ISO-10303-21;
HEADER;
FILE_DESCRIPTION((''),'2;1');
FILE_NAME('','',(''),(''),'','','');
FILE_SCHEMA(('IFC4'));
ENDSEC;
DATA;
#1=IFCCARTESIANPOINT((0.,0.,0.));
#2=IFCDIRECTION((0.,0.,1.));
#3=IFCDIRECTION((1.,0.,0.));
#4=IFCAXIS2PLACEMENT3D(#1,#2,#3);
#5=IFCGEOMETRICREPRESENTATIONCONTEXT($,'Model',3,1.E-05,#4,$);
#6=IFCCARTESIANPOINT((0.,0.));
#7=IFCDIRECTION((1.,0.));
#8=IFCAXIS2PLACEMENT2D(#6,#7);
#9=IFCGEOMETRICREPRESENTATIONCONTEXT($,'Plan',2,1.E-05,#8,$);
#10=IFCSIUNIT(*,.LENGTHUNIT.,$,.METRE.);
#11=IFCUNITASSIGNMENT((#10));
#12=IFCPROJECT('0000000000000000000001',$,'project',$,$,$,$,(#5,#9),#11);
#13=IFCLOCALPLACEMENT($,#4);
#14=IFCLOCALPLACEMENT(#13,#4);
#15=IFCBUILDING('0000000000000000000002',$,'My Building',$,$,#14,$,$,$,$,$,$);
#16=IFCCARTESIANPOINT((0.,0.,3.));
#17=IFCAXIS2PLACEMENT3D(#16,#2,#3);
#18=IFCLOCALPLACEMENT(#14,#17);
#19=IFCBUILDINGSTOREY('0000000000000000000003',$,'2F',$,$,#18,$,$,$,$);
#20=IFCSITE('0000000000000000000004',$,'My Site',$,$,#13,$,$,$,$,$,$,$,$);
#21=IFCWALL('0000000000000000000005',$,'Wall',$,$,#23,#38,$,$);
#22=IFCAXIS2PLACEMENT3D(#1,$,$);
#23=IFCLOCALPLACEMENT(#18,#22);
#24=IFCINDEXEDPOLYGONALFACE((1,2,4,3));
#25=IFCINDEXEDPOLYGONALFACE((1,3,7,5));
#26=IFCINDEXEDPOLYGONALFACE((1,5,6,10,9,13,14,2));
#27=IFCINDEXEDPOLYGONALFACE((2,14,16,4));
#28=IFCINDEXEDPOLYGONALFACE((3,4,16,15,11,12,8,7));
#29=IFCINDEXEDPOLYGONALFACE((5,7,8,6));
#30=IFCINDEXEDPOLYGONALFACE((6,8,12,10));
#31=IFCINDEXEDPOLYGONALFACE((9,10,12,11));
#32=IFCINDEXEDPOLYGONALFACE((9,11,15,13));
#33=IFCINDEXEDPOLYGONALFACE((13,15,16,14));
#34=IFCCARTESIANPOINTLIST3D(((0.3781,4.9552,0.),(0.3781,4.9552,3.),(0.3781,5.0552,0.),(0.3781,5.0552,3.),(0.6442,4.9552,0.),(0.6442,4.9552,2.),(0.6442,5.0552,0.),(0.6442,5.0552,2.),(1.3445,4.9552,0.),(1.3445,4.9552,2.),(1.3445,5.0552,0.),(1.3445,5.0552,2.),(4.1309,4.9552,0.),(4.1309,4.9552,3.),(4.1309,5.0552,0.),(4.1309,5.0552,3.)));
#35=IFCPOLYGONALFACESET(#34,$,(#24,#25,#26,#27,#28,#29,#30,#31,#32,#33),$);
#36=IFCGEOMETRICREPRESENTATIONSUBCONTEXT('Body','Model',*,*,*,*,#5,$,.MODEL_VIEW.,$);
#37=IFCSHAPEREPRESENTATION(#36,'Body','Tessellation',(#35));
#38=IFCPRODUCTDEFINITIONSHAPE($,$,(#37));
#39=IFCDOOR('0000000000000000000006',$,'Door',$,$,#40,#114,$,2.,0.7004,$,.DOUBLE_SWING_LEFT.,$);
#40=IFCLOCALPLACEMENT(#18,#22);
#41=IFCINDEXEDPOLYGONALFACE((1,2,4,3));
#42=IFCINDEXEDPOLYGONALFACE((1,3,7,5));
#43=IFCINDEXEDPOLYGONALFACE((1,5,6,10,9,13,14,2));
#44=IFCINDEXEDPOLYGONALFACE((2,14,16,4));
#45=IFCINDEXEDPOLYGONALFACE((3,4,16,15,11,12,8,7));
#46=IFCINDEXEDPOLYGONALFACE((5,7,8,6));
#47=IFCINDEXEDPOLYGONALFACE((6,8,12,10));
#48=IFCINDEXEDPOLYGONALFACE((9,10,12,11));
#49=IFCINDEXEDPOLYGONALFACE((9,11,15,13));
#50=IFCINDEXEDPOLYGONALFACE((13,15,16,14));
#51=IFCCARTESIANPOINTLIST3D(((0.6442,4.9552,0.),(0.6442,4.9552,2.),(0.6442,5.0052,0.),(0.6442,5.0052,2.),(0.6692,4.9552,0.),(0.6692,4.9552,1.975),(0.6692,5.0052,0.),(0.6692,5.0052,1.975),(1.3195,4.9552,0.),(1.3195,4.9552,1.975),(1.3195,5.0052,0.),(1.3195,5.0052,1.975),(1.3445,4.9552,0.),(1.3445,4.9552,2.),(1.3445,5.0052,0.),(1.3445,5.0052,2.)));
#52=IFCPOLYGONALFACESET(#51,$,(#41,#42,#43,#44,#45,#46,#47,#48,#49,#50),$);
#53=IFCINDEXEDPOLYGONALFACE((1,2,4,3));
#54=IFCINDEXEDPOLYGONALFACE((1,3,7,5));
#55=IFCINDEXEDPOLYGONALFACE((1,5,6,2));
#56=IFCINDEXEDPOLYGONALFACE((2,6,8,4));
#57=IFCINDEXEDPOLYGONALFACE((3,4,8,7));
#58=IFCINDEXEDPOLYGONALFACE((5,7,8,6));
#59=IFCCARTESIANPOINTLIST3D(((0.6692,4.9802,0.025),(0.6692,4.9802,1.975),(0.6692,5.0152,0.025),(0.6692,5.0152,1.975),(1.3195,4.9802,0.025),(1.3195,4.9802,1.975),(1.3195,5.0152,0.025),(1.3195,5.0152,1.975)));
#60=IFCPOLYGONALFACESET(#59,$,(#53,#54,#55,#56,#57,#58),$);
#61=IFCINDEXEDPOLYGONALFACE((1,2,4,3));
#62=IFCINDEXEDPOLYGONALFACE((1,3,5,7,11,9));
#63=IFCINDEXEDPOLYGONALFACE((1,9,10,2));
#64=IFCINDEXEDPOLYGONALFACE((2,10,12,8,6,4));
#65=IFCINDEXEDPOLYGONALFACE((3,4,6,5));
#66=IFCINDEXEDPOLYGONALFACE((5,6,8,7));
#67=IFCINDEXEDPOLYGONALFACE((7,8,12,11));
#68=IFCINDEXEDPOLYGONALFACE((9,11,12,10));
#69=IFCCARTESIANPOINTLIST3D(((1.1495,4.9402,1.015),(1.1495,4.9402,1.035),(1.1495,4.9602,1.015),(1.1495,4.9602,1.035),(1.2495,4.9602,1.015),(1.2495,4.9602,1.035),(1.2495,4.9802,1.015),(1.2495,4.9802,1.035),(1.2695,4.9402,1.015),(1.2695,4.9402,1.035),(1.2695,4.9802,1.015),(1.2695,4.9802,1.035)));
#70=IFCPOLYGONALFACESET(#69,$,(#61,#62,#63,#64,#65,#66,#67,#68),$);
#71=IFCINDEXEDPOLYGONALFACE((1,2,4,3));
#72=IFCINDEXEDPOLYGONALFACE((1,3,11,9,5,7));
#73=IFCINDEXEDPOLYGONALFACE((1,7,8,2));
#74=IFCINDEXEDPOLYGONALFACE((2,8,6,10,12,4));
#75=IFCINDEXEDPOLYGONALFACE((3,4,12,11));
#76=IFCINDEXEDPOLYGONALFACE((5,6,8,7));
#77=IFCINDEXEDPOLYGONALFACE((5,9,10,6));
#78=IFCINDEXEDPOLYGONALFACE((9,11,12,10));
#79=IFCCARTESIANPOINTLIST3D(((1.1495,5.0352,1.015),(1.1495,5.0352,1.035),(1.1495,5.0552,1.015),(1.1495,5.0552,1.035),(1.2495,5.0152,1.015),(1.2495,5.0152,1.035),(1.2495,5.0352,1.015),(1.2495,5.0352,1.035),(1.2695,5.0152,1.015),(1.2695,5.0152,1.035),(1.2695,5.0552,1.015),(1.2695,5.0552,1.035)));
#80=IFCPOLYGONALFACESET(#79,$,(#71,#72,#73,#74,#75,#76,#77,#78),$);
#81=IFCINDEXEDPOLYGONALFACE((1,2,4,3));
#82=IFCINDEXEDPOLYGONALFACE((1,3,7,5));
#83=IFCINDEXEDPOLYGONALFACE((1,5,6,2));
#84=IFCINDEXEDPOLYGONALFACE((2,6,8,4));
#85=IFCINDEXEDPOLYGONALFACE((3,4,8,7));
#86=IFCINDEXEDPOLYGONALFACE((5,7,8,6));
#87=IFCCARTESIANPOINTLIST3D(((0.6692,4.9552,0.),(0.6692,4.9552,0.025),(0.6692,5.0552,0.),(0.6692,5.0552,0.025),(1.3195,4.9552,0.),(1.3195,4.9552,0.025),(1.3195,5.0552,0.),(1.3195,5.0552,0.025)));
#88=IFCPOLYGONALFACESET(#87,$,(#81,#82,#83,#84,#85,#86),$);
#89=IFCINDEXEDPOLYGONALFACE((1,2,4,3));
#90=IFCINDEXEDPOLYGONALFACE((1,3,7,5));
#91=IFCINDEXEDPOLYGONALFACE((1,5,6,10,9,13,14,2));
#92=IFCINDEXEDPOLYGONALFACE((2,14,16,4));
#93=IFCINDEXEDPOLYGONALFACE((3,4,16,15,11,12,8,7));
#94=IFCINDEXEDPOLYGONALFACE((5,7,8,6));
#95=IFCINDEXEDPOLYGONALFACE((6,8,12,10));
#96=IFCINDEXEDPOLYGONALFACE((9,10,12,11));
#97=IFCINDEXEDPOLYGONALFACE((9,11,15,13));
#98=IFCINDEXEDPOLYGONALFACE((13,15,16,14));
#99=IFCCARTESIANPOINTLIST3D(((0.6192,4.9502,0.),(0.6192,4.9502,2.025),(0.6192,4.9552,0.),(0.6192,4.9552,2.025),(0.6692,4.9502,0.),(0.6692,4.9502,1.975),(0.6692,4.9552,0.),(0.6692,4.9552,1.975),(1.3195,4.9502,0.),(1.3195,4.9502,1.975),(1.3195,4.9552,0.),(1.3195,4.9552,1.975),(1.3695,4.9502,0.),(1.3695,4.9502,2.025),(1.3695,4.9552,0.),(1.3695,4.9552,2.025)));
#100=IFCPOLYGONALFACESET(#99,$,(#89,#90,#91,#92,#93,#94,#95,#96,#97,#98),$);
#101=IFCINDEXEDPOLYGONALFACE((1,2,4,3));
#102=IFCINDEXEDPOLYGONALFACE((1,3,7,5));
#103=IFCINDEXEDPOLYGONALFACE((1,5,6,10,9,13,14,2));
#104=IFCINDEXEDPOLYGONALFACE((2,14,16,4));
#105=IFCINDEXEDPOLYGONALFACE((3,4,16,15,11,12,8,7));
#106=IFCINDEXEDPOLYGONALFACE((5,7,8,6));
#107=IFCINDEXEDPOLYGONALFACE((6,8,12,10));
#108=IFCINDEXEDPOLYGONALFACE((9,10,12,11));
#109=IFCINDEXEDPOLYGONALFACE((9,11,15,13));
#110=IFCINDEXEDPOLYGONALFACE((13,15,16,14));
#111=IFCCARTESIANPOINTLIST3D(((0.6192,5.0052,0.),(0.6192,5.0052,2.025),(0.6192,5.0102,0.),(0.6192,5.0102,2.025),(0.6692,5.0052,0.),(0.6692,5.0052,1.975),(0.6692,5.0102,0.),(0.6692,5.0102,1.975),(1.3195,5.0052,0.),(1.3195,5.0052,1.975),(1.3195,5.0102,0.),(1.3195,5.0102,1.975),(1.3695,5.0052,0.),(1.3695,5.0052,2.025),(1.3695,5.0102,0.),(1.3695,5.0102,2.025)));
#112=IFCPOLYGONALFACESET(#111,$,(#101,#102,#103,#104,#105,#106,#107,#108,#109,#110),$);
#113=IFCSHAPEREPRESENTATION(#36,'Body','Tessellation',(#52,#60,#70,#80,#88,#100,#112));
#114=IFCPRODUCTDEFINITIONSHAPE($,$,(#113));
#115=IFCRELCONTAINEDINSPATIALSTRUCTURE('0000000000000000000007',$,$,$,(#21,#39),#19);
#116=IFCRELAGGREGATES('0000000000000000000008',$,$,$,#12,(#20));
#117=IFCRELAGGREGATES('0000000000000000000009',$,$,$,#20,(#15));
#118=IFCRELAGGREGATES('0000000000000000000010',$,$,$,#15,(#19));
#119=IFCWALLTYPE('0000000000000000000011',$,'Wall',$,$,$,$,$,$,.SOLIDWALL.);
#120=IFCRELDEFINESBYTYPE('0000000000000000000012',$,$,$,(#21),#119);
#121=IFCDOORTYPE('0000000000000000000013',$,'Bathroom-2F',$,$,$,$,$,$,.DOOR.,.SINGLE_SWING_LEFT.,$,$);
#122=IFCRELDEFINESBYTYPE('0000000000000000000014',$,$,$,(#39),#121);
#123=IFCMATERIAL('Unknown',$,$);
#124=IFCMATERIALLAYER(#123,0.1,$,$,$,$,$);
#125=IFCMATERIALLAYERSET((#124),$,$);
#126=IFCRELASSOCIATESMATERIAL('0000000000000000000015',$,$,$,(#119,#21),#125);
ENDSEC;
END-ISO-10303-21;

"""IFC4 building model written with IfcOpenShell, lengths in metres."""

from ifc_helpers import new_model, entity, si_unit, frame, origin_with_axes, origin_2d_with_axis, place, context, subcontext, project, spatial, line, indexed_curve, outline, extrude, shape, source, transform, mapped, material, layer, layer_set, layer_usage, type_object, type_shapes, element, fill, save


model = new_model("IFC4")

# Units and contexts
model_context = context("Model", 3, precision=1e-05, world=origin_with_axes())
plan_context = context("Plan", 2, precision=1e-05, world=origin_2d_with_axis())
body_context_1 = subcontext(model_context, "Body", "Model", "MODEL_VIEW")
body_context_2 = subcontext(plan_context, "Body", "Plan", "PLAN_VIEW")
ifc_project = project(units=[si_unit("LENGTHUNIT", "METRE")], contexts=[model_context, plan_context])

# Site, building, storey
site_placement = place(None, origin_with_axes())
site = spatial("IfcSite", under=ifc_project, at=site_placement, Name="My Site")
building_placement = place(site_placement, origin_with_axes())
building = spatial("IfcBuilding", under=site, at=building_placement, Name="My Building")
storey_placement = place(building_placement, frame((0.0, 0.0, 3.0), z_axis=(0.0, 0.0, 1.0), x_axis=(1.0, 0.0, 0.0)))
storey = spatial("IfcBuildingStorey", under=building, at=storey_placement, Name="2F")

# Shared definitions
ifc_material = material(Name="Unknown")
ifc_layer = layer(ifc_material, 0.1)
ifc_layer_set = layer_set([ifc_layer])
wall_type = type_object("IfcWallType", Name="Wall", PredefinedType="SOLIDWALL", material=ifc_layer_set)

# Wall, opening, door
ifc_layer_usage_1 = layer_usage(ifc_layer_set, "AXIS2", "POSITIVE", 0.0)
wall_1_placement = place(storey_placement, frame((4.2309, 5.0552, 0.0), z_axis=(0.0, 0.0, 1.0), x_axis=(-1.0, 0.0, 0.0)))
wall_1 = element("IfcWall", 1, at=wall_1_placement, inside=storey, type_object=wall_type, material=ifc_layer_usage_1, Name="Wall", context=body_context_1, shape_type="SweptSolid", body=[
    extrude(outline(indexed_curve([(0.1, 0.0), (0.1, 0.1), (3.8528, 0.1), (3.8528, 0.0)], segments=[line(1, 2, 3, 4, 1)])), origin_with_axes(), (0.0, 0.0, 1.0), 3.0),
])
shared_shape_1 = source(origin_with_axes(), body_context_1, "Body", "SweptSolid", [
    extrude(outline(indexed_curve([(0.0, 0.0), (0.7004, 0.0), (0.7004, 2.0), (0.0, 2.0)], segments=[line(1, 2, 3, 4, 1)])), frame((0.0, -0.6, 0.0), z_axis=(0.0, -1.0, 0.0), x_axis=(1.0, 0.0, 0.0)), (0.0, 0.0, -1.0), 1.2),
])
opening_1_placement = place(wall_1_placement, frame((3.5867, 0.1, 0.0), z_axis=(0.0, 0.0, 1.0), x_axis=(-1.0, 0.0, 0.0)))
opening_1 = element("IfcOpeningElement", 2, at=opening_1_placement, cuts=wall_1, PredefinedType="OPENING", context=body_context_1, shape_type="MappedRepresentation", body=[
    mapped(shared_shape_1, transform((0.0, 0.0, 0.0), x_axis=(1.0, 0.0, 0.0), y_axis=(0.0, 1.0, 0.0), z_axis=(0.0, 0.0, 1.0), scale=1.0)),
])
door_type_1 = type_object("IfcDoorType", Name="Bathroom-2F", OperationType="SINGLE_SWING_LEFT", PredefinedType="DOOR")
shared_shape_2 = source(origin_with_axes(), body_context_1, "Body", "SweptSolid", [
    extrude(outline(indexed_curve([(0.0, 0.0), (0.0, 2.0), (0.7004, 2.0), (0.7004, 0.0), (0.6754, 0.0), (0.6754, 1.975), (0.025, 1.975), (0.025, 0.0)], segments=[line(1, 2, 3, 4, 5, 6, 7, 8, 1)])), frame((0.0, 0.0, 0.0), z_axis=(0.0, -1.0, 0.0), x_axis=(1.0, 0.0, 0.0)), (0.0, 0.0, -1.0), 0.05),
    extrude(outline(indexed_curve([(0.0, 0.0), (0.6504, 0.0), (0.6504, 0.035), (0.0, 0.035)], segments=[line(1, 2, 3, 4, 1)])), frame((0.025, 0.025, 0.025), z_axis=(0.0, 0.0, 1.0), x_axis=(1.0, 0.0, 0.0)), (0.0, 0.0, 1.0), 1.95),
    extrude(outline(indexed_curve([(0.0, 0.0), (0.0, -0.04), (-0.12, -0.04), (-0.12, -0.02), (-0.02, -0.02), (-0.02, 0.0)], segments=[line(1, 2, 3, 4, 5, 6, 1)])), frame((0.6254, 0.025, 1.015), z_axis=(0.0, 0.0, 1.0), x_axis=(1.0, 0.0, 0.0)), (0.0, 0.0, 1.0), 0.02),
    extrude(outline(indexed_curve([(0.0, 0.0), (0.0, 0.04), (-0.12, 0.04), (-0.12, 0.02), (-0.02, 0.02), (-0.02, 0.0)], segments=[line(1, 2, 3, 4, 5, 6, 1)])), frame((0.6254, 0.06, 1.015), z_axis=(0.0, 0.0, 1.0), x_axis=(1.0, 0.0, 0.0)), (0.0, 0.0, 1.0), 0.02),
    extrude(outline(indexed_curve([(0.0, 0.0), (0.6504, 0.0), (0.6504, 0.1), (0.0, 0.1)], segments=[line(1, 2, 3, 4, 1)])), frame((0.025, 0.0, 0.0), z_axis=(0.0, 0.0, 1.0), x_axis=(1.0, 0.0, 0.0)), (0.0, 0.0, 1.0), 0.025),
    extrude(outline(indexed_curve([(0.0, 0.0), (0.0, 2.025), (0.7504, 2.025), (0.7504, 0.0), (0.7004, 0.0), (0.7004, 1.975), (0.05, 1.975), (0.05, 0.0)], segments=[line(1, 2, 3, 4, 5, 6, 7, 8, 1)])), frame((-0.025, -0.005, 0.0), z_axis=(0.0, -1.0, 0.0), x_axis=(1.0, 0.0, 0.0)), (0.0, 0.0, -1.0), 0.005),
    extrude(outline(indexed_curve([(0.0, 0.0), (0.0, 2.025), (0.7504, 2.025), (0.7504, 0.0), (0.7004, 0.0), (0.7004, 1.975), (0.05, 1.975), (0.05, 0.0)], segments=[line(1, 2, 3, 4, 5, 6, 7, 8, 1)])), frame((-0.025, 0.05, 0.0), z_axis=(0.0, -1.0, 0.0), x_axis=(1.0, 0.0, 0.0)), (0.0, 0.0, -1.0), 0.005),
])
shared_shape_3 = source(origin_with_axes(), body_context_2, "Body", "Curve2D", [
    entity("IfcIndexedPolyCurve", entity("IfcCartesianPointList2D", [[0.0, 0.0], [0.025, 0.0], [0.025, 0.05], [0.0, 0.05]]), [entity("IfcLineIndex", [1, 2, 3, 4, 1])]),
    entity("IfcIndexedPolyCurve", entity("IfcCartesianPointList2D", [[0.7004, 0.0], [0.6754, 0.0], [0.6754, 0.05], [0.7004, 0.05]]), [entity("IfcLineIndex", [1, 2, 3, 4, 1])]),
    entity("IfcIndexedPolyCurve", entity("IfcCartesianPointList2D", [[0.025, 0.05], [0.025, -0.6004], [0.06, -0.6004]])),
    entity("IfcTrimmedCurve", entity("IfcEllipse", entity("IfcAxis2Placement2D", entity("IfcCartesianPoint", [0.06, 0.05]), entity("IfcDirection", [1.0, 0.0])), 0.6154, 0.6504), [entity("IfcCartesianPoint", [0.06, -0.6004])], [entity("IfcCartesianPoint", [0.06, 0.7004])], True, "CARTESIAN"),
    entity("IfcIndexedPolyCurve", entity("IfcCartesianPointList2D", [[0.025, 0.05], [0.06, 0.05], [0.06, 0.7004], [0.025, 0.7004]]), [entity("IfcLineIndex", [1, 2, 3, 4, 1])]),
])
type_shapes(door_type_1, [shared_shape_2, shared_shape_3])
door_1_placement = place(opening_1_placement, origin_with_axes())
door_1 = element("IfcDoor", 3, at=door_1_placement, inside=storey, type_object=door_type_1, Name="Door", OperationType="DOUBLE_SWING_LEFT", OverallHeight=2.0, OverallWidth=0.7004, shapes=[
    shape(body_context_1, "Body", "MappedRepresentation", [mapped(shared_shape_2, transform((0.0, 0.0, 0.0), x_axis=(1.0, 0.0, 0.0), y_axis=(0.0, 1.0, 0.0), z_axis=(0.0, 0.0, 1.0), scale=1.0))]),
    shape(body_context_2, "Body", "MappedRepresentation", [mapped(shared_shape_3, transform((0.0, 0.0, 0.0), x_axis=(1.0, 0.0, 0.0), y_axis=(0.0, 1.0, 0.0), z_axis=(0.0, 0.0, 1.0), scale=1.0))]),
])
fill(opening_1, door_1)

save(model, "model.ifc")
